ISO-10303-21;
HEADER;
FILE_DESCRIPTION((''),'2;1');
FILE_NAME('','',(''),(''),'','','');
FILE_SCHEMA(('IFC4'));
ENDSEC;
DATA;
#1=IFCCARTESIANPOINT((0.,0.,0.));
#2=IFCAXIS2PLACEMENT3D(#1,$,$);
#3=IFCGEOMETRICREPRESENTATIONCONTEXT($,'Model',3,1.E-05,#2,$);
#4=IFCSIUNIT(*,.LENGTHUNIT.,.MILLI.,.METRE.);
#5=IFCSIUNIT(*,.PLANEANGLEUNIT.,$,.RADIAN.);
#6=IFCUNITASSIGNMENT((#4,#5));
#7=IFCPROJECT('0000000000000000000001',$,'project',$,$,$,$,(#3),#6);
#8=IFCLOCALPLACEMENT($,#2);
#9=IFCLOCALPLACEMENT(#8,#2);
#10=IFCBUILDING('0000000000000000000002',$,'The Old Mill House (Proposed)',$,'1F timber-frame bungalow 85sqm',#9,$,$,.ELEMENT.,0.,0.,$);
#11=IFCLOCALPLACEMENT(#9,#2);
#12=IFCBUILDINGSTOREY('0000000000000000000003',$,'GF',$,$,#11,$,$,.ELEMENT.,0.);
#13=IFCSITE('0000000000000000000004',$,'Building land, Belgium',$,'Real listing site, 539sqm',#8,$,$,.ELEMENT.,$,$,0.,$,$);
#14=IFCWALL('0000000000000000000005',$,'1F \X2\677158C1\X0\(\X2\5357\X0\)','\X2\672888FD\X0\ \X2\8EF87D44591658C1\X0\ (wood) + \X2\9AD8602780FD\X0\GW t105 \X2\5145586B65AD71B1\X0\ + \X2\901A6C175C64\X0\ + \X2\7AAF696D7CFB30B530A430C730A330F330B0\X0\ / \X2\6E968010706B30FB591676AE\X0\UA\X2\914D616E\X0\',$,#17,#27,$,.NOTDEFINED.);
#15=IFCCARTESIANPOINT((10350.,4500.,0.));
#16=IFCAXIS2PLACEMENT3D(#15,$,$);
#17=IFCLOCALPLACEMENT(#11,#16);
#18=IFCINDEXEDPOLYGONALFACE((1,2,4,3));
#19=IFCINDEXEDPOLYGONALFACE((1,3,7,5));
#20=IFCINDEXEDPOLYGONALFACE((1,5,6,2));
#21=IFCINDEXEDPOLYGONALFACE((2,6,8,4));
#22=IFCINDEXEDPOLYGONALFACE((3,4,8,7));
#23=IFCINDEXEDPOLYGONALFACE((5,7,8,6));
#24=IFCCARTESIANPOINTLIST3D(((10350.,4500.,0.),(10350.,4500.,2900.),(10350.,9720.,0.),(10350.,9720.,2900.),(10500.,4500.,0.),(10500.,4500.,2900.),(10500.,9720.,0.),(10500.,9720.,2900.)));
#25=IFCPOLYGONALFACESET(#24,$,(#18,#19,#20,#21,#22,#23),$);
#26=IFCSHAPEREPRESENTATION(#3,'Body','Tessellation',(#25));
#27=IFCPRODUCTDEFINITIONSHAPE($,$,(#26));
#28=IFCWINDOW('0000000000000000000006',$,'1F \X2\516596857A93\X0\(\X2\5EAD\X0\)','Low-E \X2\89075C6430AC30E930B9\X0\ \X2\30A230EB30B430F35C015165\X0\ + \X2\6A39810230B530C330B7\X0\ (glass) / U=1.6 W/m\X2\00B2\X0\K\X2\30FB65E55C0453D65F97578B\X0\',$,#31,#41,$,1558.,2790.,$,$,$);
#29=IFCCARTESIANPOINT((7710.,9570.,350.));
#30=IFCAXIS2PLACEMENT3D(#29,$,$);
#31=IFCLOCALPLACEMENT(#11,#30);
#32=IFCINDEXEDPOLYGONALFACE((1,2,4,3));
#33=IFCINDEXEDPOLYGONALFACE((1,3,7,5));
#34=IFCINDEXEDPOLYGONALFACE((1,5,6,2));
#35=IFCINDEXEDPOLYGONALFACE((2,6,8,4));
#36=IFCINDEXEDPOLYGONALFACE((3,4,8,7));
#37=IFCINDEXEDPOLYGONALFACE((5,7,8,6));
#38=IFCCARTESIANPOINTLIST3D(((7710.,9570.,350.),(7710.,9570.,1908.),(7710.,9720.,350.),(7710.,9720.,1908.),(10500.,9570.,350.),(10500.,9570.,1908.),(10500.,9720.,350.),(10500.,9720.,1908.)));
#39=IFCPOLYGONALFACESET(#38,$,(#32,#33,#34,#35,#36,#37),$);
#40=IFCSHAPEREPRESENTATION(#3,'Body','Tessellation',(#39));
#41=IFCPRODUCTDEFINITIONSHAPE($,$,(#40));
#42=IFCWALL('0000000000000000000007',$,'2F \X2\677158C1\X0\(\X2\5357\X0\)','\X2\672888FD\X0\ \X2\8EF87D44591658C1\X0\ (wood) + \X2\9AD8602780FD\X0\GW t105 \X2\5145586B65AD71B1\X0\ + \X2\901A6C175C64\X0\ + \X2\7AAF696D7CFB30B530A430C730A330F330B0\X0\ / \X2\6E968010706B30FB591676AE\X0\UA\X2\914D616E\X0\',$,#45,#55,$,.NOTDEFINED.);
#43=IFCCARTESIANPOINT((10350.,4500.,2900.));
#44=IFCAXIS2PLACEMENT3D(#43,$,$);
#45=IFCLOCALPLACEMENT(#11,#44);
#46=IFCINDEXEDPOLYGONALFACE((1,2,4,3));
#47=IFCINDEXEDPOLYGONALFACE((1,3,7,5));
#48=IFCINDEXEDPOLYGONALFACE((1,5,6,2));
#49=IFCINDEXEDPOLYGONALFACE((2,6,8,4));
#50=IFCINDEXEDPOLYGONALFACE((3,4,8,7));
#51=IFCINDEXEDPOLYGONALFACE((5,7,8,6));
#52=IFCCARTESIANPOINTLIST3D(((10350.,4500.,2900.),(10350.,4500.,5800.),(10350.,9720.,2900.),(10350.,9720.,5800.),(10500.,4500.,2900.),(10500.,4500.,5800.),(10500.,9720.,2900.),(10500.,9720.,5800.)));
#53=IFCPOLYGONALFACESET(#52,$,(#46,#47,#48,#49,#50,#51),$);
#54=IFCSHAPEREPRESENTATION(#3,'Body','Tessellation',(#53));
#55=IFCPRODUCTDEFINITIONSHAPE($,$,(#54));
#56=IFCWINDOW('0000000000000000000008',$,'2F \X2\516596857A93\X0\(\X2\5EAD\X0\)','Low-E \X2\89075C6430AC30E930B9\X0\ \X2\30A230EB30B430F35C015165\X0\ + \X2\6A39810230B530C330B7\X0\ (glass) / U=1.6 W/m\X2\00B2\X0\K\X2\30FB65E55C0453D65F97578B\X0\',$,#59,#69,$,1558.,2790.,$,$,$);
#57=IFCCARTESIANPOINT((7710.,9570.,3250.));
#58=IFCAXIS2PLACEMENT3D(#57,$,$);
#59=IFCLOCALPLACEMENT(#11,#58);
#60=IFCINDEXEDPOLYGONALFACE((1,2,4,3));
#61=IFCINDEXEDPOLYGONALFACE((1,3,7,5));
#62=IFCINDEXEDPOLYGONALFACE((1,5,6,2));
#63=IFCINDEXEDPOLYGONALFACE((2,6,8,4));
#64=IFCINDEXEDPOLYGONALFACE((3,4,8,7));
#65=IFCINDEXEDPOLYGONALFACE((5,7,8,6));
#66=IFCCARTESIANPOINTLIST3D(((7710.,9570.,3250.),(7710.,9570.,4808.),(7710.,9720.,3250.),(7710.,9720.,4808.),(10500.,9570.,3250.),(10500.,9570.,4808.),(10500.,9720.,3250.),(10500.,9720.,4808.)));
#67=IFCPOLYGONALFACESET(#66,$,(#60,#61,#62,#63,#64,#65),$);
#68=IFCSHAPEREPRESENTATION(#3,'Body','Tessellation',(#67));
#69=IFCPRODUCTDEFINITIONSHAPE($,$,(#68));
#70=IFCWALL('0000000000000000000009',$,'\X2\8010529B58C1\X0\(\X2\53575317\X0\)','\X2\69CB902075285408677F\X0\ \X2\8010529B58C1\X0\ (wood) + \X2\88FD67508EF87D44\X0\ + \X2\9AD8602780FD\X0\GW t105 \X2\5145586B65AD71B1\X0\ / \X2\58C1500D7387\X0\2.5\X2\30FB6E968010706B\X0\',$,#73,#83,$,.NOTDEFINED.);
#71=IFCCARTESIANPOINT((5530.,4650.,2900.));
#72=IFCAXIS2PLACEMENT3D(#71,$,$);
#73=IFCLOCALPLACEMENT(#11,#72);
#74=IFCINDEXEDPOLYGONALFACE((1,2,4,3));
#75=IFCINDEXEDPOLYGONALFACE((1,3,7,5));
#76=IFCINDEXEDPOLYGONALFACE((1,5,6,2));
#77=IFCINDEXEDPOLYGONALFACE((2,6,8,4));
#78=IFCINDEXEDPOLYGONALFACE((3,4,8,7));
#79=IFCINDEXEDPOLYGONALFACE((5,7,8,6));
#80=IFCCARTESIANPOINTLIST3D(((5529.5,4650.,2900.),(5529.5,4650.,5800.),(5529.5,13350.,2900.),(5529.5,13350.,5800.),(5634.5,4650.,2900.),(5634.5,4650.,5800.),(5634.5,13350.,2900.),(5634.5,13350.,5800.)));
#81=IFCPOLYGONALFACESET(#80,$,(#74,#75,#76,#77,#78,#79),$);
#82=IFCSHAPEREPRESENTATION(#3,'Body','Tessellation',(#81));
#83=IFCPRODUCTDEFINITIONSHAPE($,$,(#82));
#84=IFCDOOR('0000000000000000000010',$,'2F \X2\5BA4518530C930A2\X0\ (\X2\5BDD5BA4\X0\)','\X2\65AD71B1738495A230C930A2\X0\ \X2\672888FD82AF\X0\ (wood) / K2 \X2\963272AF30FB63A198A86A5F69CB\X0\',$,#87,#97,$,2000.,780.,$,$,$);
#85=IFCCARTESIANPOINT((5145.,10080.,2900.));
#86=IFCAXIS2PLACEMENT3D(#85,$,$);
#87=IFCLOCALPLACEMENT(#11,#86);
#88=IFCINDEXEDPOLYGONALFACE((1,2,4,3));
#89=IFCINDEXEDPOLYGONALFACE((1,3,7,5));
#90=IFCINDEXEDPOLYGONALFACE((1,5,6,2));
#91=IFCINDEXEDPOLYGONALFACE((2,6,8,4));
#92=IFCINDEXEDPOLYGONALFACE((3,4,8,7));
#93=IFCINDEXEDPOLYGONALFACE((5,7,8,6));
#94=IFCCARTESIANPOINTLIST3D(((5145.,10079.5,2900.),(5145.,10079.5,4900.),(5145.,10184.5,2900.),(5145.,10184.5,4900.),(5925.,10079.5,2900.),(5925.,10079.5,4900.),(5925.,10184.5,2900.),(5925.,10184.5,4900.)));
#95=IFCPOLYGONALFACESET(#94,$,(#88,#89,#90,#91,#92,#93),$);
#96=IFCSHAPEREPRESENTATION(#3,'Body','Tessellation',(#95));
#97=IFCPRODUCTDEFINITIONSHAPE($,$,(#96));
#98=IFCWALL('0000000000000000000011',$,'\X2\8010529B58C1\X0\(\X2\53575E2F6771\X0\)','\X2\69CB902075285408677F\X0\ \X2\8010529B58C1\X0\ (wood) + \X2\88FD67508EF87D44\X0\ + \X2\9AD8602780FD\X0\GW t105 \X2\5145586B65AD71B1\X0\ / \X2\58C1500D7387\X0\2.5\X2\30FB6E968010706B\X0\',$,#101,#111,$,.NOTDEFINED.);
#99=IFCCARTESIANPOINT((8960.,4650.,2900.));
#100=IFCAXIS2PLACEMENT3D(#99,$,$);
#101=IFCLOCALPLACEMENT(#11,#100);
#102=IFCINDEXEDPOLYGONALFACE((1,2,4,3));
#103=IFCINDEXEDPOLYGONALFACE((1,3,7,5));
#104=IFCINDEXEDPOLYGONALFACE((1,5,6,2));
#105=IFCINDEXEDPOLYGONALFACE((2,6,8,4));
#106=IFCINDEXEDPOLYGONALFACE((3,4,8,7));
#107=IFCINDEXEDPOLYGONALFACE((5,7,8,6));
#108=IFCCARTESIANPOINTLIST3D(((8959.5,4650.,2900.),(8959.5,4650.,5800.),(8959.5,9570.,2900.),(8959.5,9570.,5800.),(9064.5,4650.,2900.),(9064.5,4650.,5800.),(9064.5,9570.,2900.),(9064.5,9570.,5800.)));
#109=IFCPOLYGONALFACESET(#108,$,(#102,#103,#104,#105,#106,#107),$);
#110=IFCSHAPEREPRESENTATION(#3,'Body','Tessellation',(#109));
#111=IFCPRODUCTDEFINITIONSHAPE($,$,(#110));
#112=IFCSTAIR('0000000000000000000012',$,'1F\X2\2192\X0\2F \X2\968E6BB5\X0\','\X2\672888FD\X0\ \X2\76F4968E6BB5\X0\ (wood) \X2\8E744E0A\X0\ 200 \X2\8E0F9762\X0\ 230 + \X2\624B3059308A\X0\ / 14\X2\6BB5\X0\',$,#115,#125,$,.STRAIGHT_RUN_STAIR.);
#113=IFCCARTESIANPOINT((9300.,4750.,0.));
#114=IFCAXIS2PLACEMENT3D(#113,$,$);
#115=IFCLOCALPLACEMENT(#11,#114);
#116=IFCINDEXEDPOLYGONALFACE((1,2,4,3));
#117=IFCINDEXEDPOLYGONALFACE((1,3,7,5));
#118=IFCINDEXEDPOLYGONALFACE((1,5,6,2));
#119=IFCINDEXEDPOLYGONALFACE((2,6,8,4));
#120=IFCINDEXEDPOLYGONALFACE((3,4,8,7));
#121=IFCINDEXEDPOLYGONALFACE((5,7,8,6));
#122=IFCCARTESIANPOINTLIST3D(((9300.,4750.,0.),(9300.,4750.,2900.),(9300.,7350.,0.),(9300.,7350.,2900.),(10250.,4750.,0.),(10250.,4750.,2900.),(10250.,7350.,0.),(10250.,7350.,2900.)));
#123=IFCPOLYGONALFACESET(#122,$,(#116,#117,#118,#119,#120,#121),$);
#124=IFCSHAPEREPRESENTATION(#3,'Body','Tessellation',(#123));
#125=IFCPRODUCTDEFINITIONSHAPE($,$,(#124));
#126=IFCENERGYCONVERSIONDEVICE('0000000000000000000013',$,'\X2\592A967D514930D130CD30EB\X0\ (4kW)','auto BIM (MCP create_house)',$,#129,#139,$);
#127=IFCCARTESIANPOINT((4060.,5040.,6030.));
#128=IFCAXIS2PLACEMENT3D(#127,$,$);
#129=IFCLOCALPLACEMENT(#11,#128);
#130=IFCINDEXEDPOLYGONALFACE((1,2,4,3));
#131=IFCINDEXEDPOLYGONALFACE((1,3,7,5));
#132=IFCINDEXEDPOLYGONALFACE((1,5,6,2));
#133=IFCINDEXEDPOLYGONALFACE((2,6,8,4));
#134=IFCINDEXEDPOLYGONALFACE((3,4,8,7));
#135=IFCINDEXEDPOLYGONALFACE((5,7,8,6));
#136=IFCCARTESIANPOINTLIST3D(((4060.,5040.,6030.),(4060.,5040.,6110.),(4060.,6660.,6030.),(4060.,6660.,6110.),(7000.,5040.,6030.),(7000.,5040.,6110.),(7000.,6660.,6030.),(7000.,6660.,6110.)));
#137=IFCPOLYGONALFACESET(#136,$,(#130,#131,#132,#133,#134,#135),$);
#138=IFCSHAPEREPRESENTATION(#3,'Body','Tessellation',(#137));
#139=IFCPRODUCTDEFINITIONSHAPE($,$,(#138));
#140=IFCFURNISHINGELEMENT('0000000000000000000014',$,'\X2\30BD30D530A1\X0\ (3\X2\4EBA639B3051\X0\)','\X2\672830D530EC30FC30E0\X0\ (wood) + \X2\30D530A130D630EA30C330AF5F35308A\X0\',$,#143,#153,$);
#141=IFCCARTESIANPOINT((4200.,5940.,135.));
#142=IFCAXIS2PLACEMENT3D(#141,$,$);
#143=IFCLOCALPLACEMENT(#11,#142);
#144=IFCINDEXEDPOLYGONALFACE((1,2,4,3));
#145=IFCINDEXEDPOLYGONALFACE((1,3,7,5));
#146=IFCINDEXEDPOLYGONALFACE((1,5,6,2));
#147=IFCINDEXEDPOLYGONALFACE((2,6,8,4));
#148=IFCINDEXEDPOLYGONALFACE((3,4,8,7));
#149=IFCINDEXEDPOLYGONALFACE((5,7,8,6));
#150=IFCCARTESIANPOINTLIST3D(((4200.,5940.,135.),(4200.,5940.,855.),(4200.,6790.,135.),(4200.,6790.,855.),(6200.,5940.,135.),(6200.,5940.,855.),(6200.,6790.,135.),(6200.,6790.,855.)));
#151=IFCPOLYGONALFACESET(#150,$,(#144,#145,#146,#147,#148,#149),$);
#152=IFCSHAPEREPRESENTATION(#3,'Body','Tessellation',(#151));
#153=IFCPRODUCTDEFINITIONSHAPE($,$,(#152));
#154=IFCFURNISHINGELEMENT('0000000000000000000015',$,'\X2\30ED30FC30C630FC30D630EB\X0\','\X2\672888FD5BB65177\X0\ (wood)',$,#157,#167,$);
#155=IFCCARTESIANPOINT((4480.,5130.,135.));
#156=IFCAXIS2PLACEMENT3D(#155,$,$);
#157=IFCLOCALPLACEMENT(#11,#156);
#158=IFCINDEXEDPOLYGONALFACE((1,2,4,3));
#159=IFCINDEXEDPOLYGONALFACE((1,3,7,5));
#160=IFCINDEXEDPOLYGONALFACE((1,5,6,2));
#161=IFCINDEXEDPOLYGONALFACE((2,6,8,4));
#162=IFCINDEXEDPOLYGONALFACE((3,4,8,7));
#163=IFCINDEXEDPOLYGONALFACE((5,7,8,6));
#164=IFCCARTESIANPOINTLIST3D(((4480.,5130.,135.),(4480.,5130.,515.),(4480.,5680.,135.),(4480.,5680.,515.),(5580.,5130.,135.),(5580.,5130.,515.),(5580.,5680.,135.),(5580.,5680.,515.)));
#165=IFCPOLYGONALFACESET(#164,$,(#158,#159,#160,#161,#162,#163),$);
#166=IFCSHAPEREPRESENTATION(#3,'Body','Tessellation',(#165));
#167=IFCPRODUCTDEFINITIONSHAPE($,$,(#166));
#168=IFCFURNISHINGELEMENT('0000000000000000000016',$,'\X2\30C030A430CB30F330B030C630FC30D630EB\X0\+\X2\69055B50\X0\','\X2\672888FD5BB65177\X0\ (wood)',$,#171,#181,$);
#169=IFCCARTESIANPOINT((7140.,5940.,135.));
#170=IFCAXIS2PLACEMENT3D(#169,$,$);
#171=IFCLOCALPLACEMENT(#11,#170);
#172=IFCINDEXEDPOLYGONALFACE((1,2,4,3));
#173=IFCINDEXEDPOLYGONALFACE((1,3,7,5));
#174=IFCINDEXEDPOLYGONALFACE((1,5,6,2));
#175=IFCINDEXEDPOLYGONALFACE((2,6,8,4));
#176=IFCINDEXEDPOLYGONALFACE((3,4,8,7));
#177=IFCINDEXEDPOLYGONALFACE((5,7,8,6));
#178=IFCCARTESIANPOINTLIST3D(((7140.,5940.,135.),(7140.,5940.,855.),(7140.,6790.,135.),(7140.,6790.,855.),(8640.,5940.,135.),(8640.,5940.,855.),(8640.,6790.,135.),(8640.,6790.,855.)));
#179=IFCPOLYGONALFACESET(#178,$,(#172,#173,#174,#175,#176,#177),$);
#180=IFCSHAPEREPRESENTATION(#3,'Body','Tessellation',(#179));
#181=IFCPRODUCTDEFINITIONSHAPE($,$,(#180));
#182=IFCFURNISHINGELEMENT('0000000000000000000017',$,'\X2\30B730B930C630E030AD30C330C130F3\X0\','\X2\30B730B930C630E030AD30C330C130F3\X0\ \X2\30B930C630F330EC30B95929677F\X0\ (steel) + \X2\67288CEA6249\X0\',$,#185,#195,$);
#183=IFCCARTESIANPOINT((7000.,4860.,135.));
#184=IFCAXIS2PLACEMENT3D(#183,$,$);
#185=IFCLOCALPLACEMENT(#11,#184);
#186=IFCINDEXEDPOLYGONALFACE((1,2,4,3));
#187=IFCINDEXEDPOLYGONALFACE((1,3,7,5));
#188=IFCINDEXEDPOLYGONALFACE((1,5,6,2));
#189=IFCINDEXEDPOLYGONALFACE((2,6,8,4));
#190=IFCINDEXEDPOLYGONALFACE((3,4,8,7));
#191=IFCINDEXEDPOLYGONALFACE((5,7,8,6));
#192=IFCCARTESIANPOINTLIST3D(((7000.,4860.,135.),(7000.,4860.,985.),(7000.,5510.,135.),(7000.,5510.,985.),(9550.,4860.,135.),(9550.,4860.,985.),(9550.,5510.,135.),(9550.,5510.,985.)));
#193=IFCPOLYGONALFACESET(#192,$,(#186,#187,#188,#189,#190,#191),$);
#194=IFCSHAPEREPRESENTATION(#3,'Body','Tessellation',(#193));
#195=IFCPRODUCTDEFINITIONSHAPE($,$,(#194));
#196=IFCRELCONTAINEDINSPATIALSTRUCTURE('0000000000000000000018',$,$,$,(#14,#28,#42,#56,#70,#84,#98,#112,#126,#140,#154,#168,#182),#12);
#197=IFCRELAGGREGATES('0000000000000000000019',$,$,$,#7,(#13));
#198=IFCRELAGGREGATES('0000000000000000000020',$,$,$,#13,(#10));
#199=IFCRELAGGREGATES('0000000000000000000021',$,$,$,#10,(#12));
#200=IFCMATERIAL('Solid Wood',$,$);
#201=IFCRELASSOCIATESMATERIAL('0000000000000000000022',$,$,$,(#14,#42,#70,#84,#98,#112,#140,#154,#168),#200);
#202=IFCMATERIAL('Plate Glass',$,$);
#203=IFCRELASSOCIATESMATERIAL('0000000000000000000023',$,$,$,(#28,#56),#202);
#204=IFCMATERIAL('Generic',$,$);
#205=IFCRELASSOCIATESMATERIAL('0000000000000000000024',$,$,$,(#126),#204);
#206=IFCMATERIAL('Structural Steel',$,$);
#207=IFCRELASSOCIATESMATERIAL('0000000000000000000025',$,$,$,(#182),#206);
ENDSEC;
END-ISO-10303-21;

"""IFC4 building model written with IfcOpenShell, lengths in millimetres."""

from ifc_helpers import new_model, si_unit, frame, frame_2d, origin, place, context, project, spatial, rectangle, extrude, material, element, fill, save


model = new_model("IFC4")

# Units and contexts
model_context = context("Model", 3, precision=1e-05, world=origin())
ifc_project = project(units=[si_unit("LENGTHUNIT", "METRE", prefix="MILLI"), si_unit("PLANEANGLEUNIT", "RADIAN")], contexts=[model_context])

# Site, building, storey
site_placement = place(None, origin())
site = spatial("IfcSite", under=ifc_project, at=site_placement, Name="Building land, Belgium", ObjectType="Real listing site, 539sqm", CompositionType="ELEMENT", RefElevation=0.0)
building_placement = place(site_placement, origin())
building = spatial("IfcBuilding", under=site, at=building_placement, Name="The Old Mill House (Proposed)", ObjectType="1F timber-frame bungalow 85sqm", CompositionType="ELEMENT", ElevationOfRefHeight=0.0, ElevationOfTerrain=0.0)
storey_placement = place(building_placement, origin())
storey = spatial("IfcBuildingStorey", under=building, at=storey_placement, Name="GF", CompositionType="ELEMENT", Elevation=0.0)

# Wall, opening, window
ifc_material_1 = material(Name="Solid Wood")
wall_1_placement = place(storey_placement, frame((10350.0, 4500.0, 0.0)))
wall_1 = element("IfcWall", 1, at=wall_1_placement, inside=storey, material=ifc_material_1, Name="1F 東壁(南)", Description="木製 軸組外壁 (wood) + 高性能GW t105 充填断熱 + 通気層 + 窯業系サイディング / 準耐火・外皮UA配慮", PredefinedType="NOTDEFINED", context=model_context, shape_type="SweptSolid", body=[
    extrude(rectangle(XDim=150.0, YDim=5220.0, at=frame_2d((75.0, 2610.0))), frame((10350.0, 4500.0, 0.0)), (0.0, 0.0, 1.0), 2900.0),
])
opening_1_placement = place(storey_placement, frame((7710.0, 9570.0, 350.0)))
opening_1 = element("IfcOpeningElement", 2, at=opening_1_placement, cuts=wall_1, PredefinedType="NOTDEFINED", context=model_context, shape_type="SweptSolid", body=[
    extrude(rectangle(XDim=2790.0, YDim=150.0, at=frame_2d((1395.0, 75.0))), frame((7710.0, 9570.0, 350.0)), (0.0, 0.0, 1.0), 1558.0),
])
ifc_material_2 = material(Name="Plate Glass")
window_1_placement = place(storey_placement, frame((7710.0, 9570.0, 350.0)))
window_1 = element("IfcWindow", 3, at=window_1_placement, inside=storey, material=ifc_material_2, Name="1F 入隅窓(庭)", Description="Low-E 複層ガラス アルゴン封入 + 樹脂サッシ (glass) / U=1.6 W/m²K・日射取得型", OverallHeight=1558.0, OverallWidth=2790.0, context=model_context, shape_type="SweptSolid", body=[
    extrude(rectangle(XDim=2790.0, YDim=150.0, at=frame_2d((1395.0, 75.0))), frame((7710.0, 9570.0, 350.0)), (0.0, 0.0, 1.0), 1558.0),
])
fill(opening_1, window_1)

# Wall, opening, window
wall_2_placement = place(storey_placement, frame((10350.0, 4500.0, 2900.0)))
wall_2 = element("IfcWall", 4, at=wall_2_placement, inside=storey, material=ifc_material_1, Name="2F 東壁(南)", Description="木製 軸組外壁 (wood) + 高性能GW t105 充填断熱 + 通気層 + 窯業系サイディング / 準耐火・外皮UA配慮", PredefinedType="NOTDEFINED", context=model_context, shape_type="SweptSolid", body=[
    extrude(rectangle(XDim=150.0, YDim=5220.0, at=frame_2d((75.0, 2610.0))), frame((10350.0, 4500.0, 2900.0)), (0.0, 0.0, 1.0), 2900.0),
])
opening_2_placement = place(storey_placement, frame((7710.0, 9570.0, 3250.0)))
opening_2 = element("IfcOpeningElement", 5, at=opening_2_placement, cuts=wall_2, PredefinedType="NOTDEFINED", context=model_context, shape_type="SweptSolid", body=[
    extrude(rectangle(XDim=2790.0, YDim=150.0, at=frame_2d((1395.0, 75.0))), frame((7710.0, 9570.0, 3250.0)), (0.0, 0.0, 1.0), 1558.0),
])
window_2_placement = place(storey_placement, frame((7710.0, 9570.0, 3250.0)))
window_2 = element("IfcWindow", 6, at=window_2_placement, inside=storey, material=ifc_material_2, Name="2F 入隅窓(庭)", Description="Low-E 複層ガラス アルゴン封入 + 樹脂サッシ (glass) / U=1.6 W/m²K・日射取得型", OverallHeight=1558.0, OverallWidth=2790.0, context=model_context, shape_type="SweptSolid", body=[
    extrude(rectangle(XDim=2790.0, YDim=150.0, at=frame_2d((1395.0, 75.0))), frame((7710.0, 9570.0, 3250.0)), (0.0, 0.0, 1.0), 1558.0),
])
fill(opening_2, window_2)

# Wall, opening, door
wall_3_placement = place(storey_placement, frame((5530.0, 4650.0, 2900.0)))
wall_3 = element("IfcWall", 7, at=wall_3_placement, inside=storey, material=ifc_material_1, Name="耐力壁(南北)", Description="構造用合板 耐力壁 (wood) + 製材軸組 + 高性能GW t105 充填断熱 / 壁倍率2.5・準耐火", PredefinedType="NOTDEFINED", context=model_context, shape_type="SweptSolid", body=[
    extrude(rectangle(XDim=105.0, YDim=8700.0, at=frame_2d((52.0, 4350.0))), frame((5530.0, 4650.0, 2900.0)), (0.0, 0.0, 1.0), 2900.0),
])
opening_3_placement = place(storey_placement, frame((5145.0, 10080.0, 2900.0)))
opening_3 = element("IfcOpeningElement", 8, at=opening_3_placement, cuts=wall_3, PredefinedType="NOTDEFINED", context=model_context, shape_type="SweptSolid", body=[
    extrude(rectangle(XDim=780.0, YDim=105.0, at=frame_2d((390.0, 52.0))), frame((5145.0, 10080.0, 2900.0)), (0.0, 0.0, 1.0), 2000.0),
])
door_1_placement = place(storey_placement, frame((5145.0, 10080.0, 2900.0)))
door_1 = element("IfcDoor", 9, at=door_1_placement, inside=storey, material=ifc_material_1, Name="2F 室内ドア (寝室)", Description="断熱玄関ドア 木製芯 (wood) / K2 防犯・採風機構", OverallHeight=2000.0, OverallWidth=780.0, context=model_context, shape_type="SweptSolid", body=[
    extrude(rectangle(XDim=780.0, YDim=105.0, at=frame_2d((390.0, 52.0))), frame((5145.0, 10080.0, 2900.0)), (0.0, 0.0, 1.0), 2000.0),
])
fill(opening_3, door_1)

# Wall
wall_4_placement = place(storey_placement, frame((8960.0, 4650.0, 2900.0)))
element("IfcWall", 10, at=wall_4_placement, inside=storey, material=ifc_material_1, Name="耐力壁(南帯東)", Description="構造用合板 耐力壁 (wood) + 製材軸組 + 高性能GW t105 充填断熱 / 壁倍率2.5・準耐火", PredefinedType="NOTDEFINED", context=model_context, shape_type="SweptSolid", body=[
    extrude(rectangle(XDim=105.0, YDim=4920.0, at=frame_2d((52.0, 2460.0))), frame((8960.0, 4650.0, 2900.0)), (0.0, 0.0, 1.0), 2900.0),
])

# Stair
stair_placement = place(storey_placement, frame((9300.0, 4750.0, 0.0)))
element("IfcStair", 11, at=stair_placement, inside=storey, material=ifc_material_1, Name="1F→2F 階段", Description="木製 直階段 (wood) 蹴上 200 踏面 230 + 手すり / 14段", PredefinedType="STRAIGHT_RUN_STAIR", context=model_context, shape_type="SweptSolid", body=[
    extrude(rectangle(XDim=950.0, YDim=2600.0, at=frame_2d((475.0, 1300.0))), frame((9300.0, 4750.0, 0.0)), (0.0, 0.0, 1.0), 2900.0),
])

# Energy conversion device
ifc_material_3 = material(Name="Generic")
energy_conversion_device_placement = place(storey_placement, frame((4060.0, 5040.0, 6030.0)))
element("IfcEnergyConversionDevice", 12, at=energy_conversion_device_placement, inside=storey, material=ifc_material_3, Name="太陽光パネル (4kW)", Description="auto BIM (MCP create_house)", context=model_context, shape_type="SweptSolid", body=[
    extrude(rectangle(XDim=2940.0, YDim=1620.0, at=frame_2d((1470.0, 810.0))), frame((4060.0, 5040.0, 6030.0)), (0.0, 0.0, 1.0), 80.0),
])

# Furnishing elements
furnishing_1_placement = place(storey_placement, frame((4200.0, 5940.0, 135.0)))
element("IfcFurnishingElement", 13, at=furnishing_1_placement, inside=storey, material=ifc_material_1, Name="ソファ (3人掛け)", Description="木フレーム (wood) + ファブリック張り", context=model_context, shape_type="SweptSolid", body=[
    extrude(rectangle(XDim=2000.0, YDim=850.0, at=frame_2d((1000.0, 425.0))), frame((4200.0, 5940.0, 135.0)), (0.0, 0.0, 1.0), 720.0),
])
furnishing_2_placement = place(storey_placement, frame((4480.0, 5130.0, 135.0)))
element("IfcFurnishingElement", 14, at=furnishing_2_placement, inside=storey, material=ifc_material_1, Name="ローテーブル", Description="木製家具 (wood)", context=model_context, shape_type="SweptSolid", body=[
    extrude(rectangle(XDim=1100.0, YDim=550.0, at=frame_2d((550.0, 275.0))), frame((4480.0, 5130.0, 135.0)), (0.0, 0.0, 1.0), 380.0),
])
furnishing_3_placement = place(storey_placement, frame((7140.0, 5940.0, 135.0)))
element("IfcFurnishingElement", 15, at=furnishing_3_placement, inside=storey, material=ifc_material_1, Name="ダイニングテーブル+椅子", Description="木製家具 (wood)", context=model_context, shape_type="SweptSolid", body=[
    extrude(rectangle(XDim=1500.0, YDim=850.0, at=frame_2d((750.0, 425.0))), frame((7140.0, 5940.0, 135.0)), (0.0, 0.0, 1.0), 720.0),
])
ifc_material_4 = material(Name="Structural Steel")
furnishing_4_placement = place(storey_placement, frame((7000.0, 4860.0, 135.0)))
element("IfcFurnishingElement", 16, at=furnishing_4_placement, inside=storey, material=ifc_material_4, Name="システムキッチン", Description="システムキッチン ステンレス天板 (steel) + 木質扉", context=model_context, shape_type="SweptSolid", body=[
    extrude(rectangle(XDim=2550.0, YDim=650.0, at=frame_2d((1275.0, 325.0))), frame((7000.0, 4860.0, 135.0)), (0.0, 0.0, 1.0), 850.0),
])

save(model, "model.ifc")
